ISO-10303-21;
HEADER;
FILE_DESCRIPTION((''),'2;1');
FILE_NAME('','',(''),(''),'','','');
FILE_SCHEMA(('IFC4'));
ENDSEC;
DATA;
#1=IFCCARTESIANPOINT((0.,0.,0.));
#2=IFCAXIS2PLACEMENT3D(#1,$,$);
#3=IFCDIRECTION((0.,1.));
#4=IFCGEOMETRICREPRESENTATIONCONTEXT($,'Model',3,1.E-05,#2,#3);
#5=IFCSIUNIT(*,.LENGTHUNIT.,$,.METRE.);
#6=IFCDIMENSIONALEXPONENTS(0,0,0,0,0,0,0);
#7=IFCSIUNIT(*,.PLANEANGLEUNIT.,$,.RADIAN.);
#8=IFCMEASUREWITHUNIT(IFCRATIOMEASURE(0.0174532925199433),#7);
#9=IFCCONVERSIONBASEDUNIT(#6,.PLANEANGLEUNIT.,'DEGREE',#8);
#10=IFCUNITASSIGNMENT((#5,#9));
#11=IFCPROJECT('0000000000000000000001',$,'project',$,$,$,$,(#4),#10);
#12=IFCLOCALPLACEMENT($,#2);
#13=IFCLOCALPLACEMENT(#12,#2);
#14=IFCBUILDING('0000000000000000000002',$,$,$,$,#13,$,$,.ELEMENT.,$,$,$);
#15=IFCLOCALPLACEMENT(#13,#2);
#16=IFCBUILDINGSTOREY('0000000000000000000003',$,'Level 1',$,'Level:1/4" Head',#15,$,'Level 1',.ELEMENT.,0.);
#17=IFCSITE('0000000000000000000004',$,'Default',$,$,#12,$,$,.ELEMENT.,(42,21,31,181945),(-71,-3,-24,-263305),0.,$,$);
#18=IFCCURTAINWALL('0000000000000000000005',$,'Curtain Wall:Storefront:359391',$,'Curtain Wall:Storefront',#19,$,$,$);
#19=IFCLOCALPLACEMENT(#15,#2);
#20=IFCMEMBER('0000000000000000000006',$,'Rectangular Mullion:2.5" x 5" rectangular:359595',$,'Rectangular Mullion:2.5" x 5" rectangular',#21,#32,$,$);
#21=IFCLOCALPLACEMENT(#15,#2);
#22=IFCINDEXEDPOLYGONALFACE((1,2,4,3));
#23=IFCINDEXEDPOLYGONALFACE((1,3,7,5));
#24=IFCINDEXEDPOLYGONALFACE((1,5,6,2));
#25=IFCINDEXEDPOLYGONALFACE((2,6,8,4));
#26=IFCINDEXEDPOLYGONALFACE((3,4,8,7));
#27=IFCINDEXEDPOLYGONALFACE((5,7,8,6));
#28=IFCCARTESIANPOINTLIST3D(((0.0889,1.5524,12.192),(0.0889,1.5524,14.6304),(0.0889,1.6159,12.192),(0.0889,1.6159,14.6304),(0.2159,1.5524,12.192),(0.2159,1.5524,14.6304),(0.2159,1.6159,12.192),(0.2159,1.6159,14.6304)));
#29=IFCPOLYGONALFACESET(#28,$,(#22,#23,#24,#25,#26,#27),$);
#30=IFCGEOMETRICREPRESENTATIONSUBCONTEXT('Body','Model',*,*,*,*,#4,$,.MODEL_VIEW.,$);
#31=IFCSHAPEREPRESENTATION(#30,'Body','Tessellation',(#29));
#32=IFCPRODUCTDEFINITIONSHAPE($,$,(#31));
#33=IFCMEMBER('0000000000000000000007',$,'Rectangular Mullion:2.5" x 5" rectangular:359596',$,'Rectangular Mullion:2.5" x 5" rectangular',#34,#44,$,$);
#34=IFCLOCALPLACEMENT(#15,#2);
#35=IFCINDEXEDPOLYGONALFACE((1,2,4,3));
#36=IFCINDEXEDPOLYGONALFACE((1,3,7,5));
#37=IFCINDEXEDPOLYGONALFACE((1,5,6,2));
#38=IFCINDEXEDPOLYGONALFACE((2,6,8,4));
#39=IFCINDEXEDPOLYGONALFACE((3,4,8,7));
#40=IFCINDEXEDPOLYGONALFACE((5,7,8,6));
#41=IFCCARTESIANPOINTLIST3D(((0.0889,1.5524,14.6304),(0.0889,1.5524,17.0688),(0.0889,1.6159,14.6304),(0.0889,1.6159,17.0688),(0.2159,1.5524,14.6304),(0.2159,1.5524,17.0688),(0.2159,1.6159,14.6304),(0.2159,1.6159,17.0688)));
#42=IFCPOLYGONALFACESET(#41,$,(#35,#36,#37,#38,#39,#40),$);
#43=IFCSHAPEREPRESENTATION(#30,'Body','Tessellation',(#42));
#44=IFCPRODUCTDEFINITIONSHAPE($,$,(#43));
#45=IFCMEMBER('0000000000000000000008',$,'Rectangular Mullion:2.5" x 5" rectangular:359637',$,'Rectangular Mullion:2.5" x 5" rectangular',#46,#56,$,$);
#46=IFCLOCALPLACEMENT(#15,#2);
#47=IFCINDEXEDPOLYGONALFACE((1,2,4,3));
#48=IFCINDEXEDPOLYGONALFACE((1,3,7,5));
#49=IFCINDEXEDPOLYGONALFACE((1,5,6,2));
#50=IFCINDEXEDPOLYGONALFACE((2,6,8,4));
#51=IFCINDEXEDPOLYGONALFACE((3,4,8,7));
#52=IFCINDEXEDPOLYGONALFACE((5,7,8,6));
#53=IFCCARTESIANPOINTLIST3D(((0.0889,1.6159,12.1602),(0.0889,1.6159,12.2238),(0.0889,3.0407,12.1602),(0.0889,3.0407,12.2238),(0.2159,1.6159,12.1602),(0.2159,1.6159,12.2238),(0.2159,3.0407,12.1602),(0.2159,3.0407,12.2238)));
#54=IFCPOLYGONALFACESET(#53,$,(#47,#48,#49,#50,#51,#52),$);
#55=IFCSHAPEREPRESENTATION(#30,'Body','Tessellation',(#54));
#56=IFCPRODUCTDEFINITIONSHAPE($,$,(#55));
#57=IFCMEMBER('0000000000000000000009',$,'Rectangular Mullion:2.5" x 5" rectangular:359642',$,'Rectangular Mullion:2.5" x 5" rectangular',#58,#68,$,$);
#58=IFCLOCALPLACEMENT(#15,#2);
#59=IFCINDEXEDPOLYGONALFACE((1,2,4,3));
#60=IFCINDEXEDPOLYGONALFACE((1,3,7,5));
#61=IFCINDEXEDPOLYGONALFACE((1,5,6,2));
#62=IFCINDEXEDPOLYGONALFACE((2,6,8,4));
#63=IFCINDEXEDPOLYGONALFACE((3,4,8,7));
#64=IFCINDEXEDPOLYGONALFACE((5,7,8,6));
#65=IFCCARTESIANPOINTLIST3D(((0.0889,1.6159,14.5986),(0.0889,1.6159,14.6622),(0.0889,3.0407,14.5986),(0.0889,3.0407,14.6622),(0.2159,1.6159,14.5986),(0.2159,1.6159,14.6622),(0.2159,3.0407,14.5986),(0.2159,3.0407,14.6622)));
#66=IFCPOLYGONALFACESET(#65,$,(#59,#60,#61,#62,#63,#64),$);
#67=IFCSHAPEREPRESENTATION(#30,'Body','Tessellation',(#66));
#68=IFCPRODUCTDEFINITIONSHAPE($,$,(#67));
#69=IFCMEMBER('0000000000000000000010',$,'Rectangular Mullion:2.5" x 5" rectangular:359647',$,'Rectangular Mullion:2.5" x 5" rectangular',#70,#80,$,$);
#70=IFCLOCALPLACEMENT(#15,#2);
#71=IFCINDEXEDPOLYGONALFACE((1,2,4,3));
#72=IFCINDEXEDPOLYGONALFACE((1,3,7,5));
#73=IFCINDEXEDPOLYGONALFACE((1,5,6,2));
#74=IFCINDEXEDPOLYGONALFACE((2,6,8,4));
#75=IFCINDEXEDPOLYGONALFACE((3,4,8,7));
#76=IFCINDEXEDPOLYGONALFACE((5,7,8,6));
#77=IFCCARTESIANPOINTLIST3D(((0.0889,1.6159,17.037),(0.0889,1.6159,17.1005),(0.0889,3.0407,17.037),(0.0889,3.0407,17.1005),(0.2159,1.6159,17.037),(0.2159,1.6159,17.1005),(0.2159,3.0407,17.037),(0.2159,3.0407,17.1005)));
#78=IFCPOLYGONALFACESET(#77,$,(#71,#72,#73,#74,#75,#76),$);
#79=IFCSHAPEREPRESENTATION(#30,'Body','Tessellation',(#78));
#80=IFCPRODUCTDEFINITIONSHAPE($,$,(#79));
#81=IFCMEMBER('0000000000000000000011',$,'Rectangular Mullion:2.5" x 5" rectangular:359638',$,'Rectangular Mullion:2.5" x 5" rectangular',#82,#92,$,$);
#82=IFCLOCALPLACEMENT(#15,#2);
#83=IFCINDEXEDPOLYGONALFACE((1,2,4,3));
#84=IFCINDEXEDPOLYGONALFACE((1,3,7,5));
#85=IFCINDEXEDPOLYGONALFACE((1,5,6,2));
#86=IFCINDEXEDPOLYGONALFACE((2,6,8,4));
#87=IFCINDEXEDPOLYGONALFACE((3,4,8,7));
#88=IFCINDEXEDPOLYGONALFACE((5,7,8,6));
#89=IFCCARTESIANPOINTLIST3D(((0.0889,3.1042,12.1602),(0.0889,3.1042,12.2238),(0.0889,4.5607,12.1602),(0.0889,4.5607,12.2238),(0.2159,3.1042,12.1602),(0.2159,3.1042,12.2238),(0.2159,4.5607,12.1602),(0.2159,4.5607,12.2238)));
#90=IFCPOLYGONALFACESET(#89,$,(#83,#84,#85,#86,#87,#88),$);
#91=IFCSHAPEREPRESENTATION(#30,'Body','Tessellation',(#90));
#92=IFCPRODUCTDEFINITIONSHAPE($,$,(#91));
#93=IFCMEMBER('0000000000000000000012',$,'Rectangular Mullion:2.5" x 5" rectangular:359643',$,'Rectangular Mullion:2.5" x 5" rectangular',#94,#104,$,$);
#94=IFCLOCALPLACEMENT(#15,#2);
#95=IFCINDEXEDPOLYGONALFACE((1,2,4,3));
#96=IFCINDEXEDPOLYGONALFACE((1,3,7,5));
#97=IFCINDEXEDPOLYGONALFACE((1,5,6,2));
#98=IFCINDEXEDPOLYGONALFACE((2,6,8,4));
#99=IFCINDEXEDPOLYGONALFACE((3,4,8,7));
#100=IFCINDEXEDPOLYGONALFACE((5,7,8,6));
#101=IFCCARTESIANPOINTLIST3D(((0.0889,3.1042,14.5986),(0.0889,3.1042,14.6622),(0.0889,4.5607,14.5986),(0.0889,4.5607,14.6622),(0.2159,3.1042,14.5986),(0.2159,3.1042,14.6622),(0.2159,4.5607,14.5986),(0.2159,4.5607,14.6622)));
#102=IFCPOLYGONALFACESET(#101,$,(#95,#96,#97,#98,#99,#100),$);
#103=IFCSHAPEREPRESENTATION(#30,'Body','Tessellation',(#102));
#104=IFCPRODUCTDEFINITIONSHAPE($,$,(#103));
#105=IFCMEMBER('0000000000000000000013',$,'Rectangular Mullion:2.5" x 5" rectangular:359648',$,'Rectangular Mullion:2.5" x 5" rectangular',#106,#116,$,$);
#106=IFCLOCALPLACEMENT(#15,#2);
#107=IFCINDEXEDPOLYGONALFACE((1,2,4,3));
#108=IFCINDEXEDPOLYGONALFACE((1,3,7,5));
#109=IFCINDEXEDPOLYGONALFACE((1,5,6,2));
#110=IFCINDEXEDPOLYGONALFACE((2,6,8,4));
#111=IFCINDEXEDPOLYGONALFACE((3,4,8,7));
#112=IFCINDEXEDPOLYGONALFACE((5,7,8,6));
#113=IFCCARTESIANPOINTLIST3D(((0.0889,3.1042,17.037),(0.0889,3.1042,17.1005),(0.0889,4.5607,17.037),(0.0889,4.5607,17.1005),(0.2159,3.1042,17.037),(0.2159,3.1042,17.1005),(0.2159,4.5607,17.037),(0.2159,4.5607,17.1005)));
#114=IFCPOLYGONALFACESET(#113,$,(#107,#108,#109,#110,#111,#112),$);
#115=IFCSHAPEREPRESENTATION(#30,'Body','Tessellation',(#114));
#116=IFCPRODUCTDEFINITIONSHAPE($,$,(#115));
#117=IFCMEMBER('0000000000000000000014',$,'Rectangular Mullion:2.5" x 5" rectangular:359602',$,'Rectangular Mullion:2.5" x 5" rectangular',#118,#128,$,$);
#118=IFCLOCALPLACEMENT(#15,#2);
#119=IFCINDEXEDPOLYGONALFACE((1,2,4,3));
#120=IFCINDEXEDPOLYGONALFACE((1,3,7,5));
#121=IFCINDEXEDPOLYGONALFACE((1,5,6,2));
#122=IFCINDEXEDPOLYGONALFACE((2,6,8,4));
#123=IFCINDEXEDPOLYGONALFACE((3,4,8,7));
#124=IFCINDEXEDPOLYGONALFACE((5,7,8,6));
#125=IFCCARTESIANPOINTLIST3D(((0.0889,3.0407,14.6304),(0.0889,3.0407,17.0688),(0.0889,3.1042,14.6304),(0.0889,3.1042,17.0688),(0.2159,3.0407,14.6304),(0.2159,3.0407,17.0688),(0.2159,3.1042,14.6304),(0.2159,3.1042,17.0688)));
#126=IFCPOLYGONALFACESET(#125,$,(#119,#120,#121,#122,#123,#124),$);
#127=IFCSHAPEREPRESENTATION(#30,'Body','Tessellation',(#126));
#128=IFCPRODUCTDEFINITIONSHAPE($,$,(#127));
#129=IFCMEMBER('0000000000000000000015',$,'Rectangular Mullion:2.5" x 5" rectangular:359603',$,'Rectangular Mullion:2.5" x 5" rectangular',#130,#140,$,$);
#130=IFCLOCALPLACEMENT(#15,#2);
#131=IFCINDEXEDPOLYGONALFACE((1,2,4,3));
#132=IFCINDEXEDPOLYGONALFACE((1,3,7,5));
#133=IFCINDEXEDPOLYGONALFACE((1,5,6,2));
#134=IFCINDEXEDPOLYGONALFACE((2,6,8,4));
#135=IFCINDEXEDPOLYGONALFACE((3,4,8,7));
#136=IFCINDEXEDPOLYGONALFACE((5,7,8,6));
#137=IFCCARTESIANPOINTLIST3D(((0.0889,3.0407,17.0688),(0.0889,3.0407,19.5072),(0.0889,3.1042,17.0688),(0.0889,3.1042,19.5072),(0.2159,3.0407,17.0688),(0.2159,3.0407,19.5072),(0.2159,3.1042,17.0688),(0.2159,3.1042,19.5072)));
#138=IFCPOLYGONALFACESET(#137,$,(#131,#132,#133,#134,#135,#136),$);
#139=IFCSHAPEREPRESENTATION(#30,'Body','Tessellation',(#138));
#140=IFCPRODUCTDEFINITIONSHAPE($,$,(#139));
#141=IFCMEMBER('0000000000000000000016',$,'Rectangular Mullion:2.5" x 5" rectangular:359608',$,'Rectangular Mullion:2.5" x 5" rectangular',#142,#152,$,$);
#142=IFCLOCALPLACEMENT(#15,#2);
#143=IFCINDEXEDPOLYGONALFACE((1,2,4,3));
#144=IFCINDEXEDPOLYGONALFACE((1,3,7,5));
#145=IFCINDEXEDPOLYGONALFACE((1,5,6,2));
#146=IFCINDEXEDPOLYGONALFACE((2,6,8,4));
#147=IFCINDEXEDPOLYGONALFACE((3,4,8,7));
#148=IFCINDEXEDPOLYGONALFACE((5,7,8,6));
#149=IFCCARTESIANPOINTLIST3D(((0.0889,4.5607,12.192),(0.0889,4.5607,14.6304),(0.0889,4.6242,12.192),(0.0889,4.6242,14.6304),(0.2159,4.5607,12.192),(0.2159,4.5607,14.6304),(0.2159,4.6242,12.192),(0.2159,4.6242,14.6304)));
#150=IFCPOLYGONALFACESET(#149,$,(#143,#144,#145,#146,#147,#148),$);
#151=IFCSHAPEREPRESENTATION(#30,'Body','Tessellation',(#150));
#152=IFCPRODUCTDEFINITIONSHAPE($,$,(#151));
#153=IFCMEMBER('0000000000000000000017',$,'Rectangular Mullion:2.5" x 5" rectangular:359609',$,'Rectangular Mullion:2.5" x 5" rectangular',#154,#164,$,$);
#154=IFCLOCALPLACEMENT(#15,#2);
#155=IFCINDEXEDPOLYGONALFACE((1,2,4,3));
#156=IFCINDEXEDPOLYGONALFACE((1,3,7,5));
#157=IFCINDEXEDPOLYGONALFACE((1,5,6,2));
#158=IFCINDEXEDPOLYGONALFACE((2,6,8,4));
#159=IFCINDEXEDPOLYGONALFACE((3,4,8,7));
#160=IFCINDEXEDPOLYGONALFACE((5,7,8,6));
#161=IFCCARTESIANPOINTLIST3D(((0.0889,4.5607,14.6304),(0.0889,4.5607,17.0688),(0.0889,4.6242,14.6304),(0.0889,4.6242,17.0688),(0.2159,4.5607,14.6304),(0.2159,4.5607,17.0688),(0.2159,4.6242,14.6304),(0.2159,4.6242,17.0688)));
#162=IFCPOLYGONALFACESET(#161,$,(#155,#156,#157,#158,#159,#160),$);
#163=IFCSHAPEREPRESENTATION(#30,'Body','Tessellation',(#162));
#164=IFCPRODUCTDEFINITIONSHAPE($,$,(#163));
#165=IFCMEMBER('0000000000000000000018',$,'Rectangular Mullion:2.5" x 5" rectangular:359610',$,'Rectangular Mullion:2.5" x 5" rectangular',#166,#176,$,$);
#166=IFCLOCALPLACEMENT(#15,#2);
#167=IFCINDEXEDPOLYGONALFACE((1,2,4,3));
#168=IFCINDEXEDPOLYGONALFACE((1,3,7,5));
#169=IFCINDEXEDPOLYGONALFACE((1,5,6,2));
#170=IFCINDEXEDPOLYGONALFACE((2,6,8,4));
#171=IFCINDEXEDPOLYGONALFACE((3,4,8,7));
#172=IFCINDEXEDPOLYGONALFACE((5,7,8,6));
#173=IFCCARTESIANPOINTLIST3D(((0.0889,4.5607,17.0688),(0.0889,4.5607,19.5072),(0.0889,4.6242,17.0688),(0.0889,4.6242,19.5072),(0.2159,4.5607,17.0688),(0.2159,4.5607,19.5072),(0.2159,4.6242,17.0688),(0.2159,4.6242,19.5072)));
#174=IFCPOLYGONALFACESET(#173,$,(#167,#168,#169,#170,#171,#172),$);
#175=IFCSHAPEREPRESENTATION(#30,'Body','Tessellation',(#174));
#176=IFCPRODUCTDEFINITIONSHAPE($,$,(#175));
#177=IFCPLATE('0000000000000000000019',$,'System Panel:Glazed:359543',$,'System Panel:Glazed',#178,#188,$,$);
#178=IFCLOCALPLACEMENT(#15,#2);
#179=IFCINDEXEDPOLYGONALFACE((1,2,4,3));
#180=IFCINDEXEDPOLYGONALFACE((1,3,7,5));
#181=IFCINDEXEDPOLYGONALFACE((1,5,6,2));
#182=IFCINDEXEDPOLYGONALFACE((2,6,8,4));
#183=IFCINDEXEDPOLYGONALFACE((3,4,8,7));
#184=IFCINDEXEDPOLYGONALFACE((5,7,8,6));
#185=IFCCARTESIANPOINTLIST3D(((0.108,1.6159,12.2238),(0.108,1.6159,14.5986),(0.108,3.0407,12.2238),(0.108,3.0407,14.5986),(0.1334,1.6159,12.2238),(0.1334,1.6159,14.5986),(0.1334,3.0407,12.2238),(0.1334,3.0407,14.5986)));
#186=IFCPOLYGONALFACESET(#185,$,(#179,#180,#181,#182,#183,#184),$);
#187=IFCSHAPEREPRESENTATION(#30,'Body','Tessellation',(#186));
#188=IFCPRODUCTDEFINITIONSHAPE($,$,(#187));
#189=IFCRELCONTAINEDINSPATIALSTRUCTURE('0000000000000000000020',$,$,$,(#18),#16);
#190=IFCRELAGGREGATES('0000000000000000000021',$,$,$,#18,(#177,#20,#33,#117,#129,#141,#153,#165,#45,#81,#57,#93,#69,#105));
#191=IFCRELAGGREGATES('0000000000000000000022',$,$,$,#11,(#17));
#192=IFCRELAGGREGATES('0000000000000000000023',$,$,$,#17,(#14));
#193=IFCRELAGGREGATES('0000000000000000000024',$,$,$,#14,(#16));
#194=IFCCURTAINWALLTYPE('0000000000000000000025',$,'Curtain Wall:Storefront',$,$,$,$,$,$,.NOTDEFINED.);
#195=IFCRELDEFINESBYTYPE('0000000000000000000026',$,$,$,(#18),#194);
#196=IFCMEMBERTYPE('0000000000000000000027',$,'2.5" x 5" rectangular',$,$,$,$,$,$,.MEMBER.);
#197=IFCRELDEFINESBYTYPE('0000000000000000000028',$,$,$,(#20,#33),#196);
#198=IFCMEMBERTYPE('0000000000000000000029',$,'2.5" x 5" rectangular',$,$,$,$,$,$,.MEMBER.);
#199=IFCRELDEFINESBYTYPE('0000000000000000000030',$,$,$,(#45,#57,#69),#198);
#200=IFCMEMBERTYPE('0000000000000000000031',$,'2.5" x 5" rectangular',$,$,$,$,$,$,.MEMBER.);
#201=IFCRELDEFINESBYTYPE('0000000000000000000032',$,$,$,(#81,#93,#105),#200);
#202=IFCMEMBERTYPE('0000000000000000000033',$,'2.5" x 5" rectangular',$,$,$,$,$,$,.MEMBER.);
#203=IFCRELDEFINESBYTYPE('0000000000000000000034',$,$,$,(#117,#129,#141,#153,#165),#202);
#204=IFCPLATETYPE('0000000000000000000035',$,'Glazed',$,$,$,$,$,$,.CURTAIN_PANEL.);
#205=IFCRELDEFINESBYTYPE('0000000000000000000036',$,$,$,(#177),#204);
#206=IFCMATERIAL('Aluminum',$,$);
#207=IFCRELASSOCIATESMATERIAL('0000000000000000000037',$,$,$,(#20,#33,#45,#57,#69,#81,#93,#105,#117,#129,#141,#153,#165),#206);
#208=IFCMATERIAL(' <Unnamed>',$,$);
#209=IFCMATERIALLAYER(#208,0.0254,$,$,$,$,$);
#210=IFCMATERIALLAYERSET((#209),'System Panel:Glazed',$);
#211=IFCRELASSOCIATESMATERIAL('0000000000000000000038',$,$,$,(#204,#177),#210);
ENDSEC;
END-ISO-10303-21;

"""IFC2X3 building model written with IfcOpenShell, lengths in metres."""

from ifc_helpers import new_model, entity, si_unit, converted_unit, direction, frame, frame_2d, origin, origin_2d_with_axis, place, context, subcontext, project, spatial, rectangle, extrude, source, transform, mapped, material, layer, layer_set, layer_usage, type_object, type_shapes, element, aggregate, save


model = new_model("IFC2X3")

# Units and contexts
model_context = context("Model", 3, precision=1e-05, world=origin(), true_north=direction((0.0, 1.0)))
body_context = subcontext(model_context, "Body", "Model", "MODEL_VIEW")
ifc_project = project(units=[si_unit("LENGTHUNIT", "METRE"), converted_unit("PLANEANGLEUNIT", "DEGREE", entity("IfcRatioMeasure", 0.0174532925199433), si_unit("PLANEANGLEUNIT", "RADIAN"), dimensions=[0, 0, 0, 0, 0, 0, 0])], contexts=[model_context])

# Site, building, storey
site_placement = place(None, origin())
site = spatial("IfcSite", under=ifc_project, at=site_placement, Name="Default", CompositionType="ELEMENT", RefLatitude=(42, 21, 31, 181945), RefLongitude=(-71, -3, -24, -263305), RefElevation=0.0)
building_placement = place(site_placement, origin())
building = spatial("IfcBuilding", under=site, at=building_placement, CompositionType="ELEMENT")
storey_placement = place(building_placement, origin())
storey = spatial("IfcBuildingStorey", under=building, at=storey_placement, Name="Level 1", ObjectType="Level:1/4\" Head", LongName="Level 1", CompositionType="ELEMENT", Elevation=0.0)

# Curtain wall, members, plate
curtain_wall_type = type_object("IfcCurtainWallType", Name="Curtain Wall:Storefront", PredefinedType="NOTDEFINED")
curtain_wall_placement = place(storey_placement, origin())
curtain_wall = element("IfcCurtainWall", 1, at=curtain_wall_placement, inside=storey, type_object=curtain_wall_type, Name="Curtain Wall:Storefront:359391", ObjectType="Curtain Wall:Storefront")
ifc_material_1 = material(Name="Aluminum")
member_type_1 = type_object("IfcMemberType", Name="2.5\" x 5\" rectangular", PredefinedType="MEMBER")
shared_shape_1 = source(origin(), body_context, "Body", "SweptSolid", [
    extrude(rectangle(XDim=0.127, YDim=0.0635, at=origin_2d_with_axis()), frame((-0.0318, 0.0, -2.4384), z_axis=(0.0, 0.0, 1.0), x_axis=(0.0, -1.0, 0.0)), (0.0, 0.0, 1.0), 2.4384),
])
type_shapes(member_type_1, [shared_shape_1])
member_1_placement = place(storey_placement, frame((0.1524, 1.5524, 14.6304), z_axis=(0.0, 0.0, 1.0), x_axis=(0.0, -1.0, 0.0)))
member_1 = element("IfcMember", 2, at=member_1_placement, type_object=member_type_1, material=ifc_material_1, Name="Rectangular Mullion:2.5\" x 5\" rectangular:359595", ObjectType="Rectangular Mullion:2.5\" x 5\" rectangular", context=body_context, shape_type="MappedRepresentation", body=[
    mapped(shared_shape_1, transform((0.0, 0.0, 0.0), scale=1.0)),
])
member_2_placement = place(storey_placement, frame((0.1524, 1.5524, 17.0688), z_axis=(0.0, 0.0, 1.0), x_axis=(0.0, -1.0, 0.0)))
member_2 = element("IfcMember", 3, at=member_2_placement, type_object=member_type_1, material=ifc_material_1, Name="Rectangular Mullion:2.5\" x 5\" rectangular:359596", ObjectType="Rectangular Mullion:2.5\" x 5\" rectangular", context=body_context, shape_type="MappedRepresentation", body=[
    mapped(shared_shape_1, transform((0.0, 0.0, 0.0), scale=1.0)),
])
member_type_2 = type_object("IfcMemberType", Name="2.5\" x 5\" rectangular", PredefinedType="MEMBER")
shared_shape_2 = source(origin(), body_context, "Body", "SweptSolid", [
    extrude(rectangle(XDim=0.127, YDim=0.0635, at=origin_2d_with_axis()), frame((0.0, 0.0, -1.4248), z_axis=(0.0, 0.0, 1.0), x_axis=(0.0, -1.0, 0.0)), (0.0, 0.0, 1.0), 1.4248),
])
type_shapes(member_type_2, [shared_shape_2])
member_3_placement = place(storey_placement, frame((0.1524, 3.0407, 12.192), z_axis=(0.0, 1.0, 0.0), x_axis=(0.0, 0.0, 1.0)))
member_3 = element("IfcMember", 4, at=member_3_placement, type_object=member_type_2, material=ifc_material_1, Name="Rectangular Mullion:2.5\" x 5\" rectangular:359637", ObjectType="Rectangular Mullion:2.5\" x 5\" rectangular", context=body_context, shape_type="MappedRepresentation", body=[
    mapped(shared_shape_2, transform((0.0, 0.0, 0.0), scale=1.0)),
])
member_4_placement = place(storey_placement, frame((0.1524, 3.0407, 14.6304), z_axis=(0.0, 1.0, 0.0), x_axis=(0.0, 0.0, 1.0)))
member_4 = element("IfcMember", 5, at=member_4_placement, type_object=member_type_2, material=ifc_material_1, Name="Rectangular Mullion:2.5\" x 5\" rectangular:359642", ObjectType="Rectangular Mullion:2.5\" x 5\" rectangular", context=body_context, shape_type="MappedRepresentation", body=[
    mapped(shared_shape_2, transform((0.0, 0.0, 0.0), scale=1.0)),
])
member_5_placement = place(storey_placement, frame((0.1524, 3.0407, 17.0688), z_axis=(0.0, 1.0, 0.0), x_axis=(0.0, 0.0, 1.0)))
member_5 = element("IfcMember", 6, at=member_5_placement, type_object=member_type_2, material=ifc_material_1, Name="Rectangular Mullion:2.5\" x 5\" rectangular:359647", ObjectType="Rectangular Mullion:2.5\" x 5\" rectangular", context=body_context, shape_type="MappedRepresentation", body=[
    mapped(shared_shape_2, transform((0.0, 0.0, 0.0), scale=1.0)),
])
member_type_3 = type_object("IfcMemberType", Name="2.5\" x 5\" rectangular", PredefinedType="MEMBER")
shared_shape_3 = source(origin(), body_context, "Body", "SweptSolid", [
    extrude(rectangle(XDim=0.127, YDim=0.0635, at=origin_2d_with_axis()), frame((0.0, 0.0, -1.4565), z_axis=(0.0, 0.0, 1.0), x_axis=(0.0, -1.0, 0.0)), (0.0, 0.0, 1.0), 1.4565),
])
type_shapes(member_type_3, [shared_shape_3])
member_6_placement = place(storey_placement, frame((0.1524, 4.5607, 12.192), z_axis=(0.0, 1.0, 0.0), x_axis=(0.0, 0.0, 1.0)))
member_6 = element("IfcMember", 7, at=member_6_placement, type_object=member_type_3, material=ifc_material_1, Name="Rectangular Mullion:2.5\" x 5\" rectangular:359638", ObjectType="Rectangular Mullion:2.5\" x 5\" rectangular", context=body_context, shape_type="MappedRepresentation", body=[
    mapped(shared_shape_3, transform((0.0, 0.0, 0.0), scale=1.0)),
])
member_7_placement = place(storey_placement, frame((0.1524, 4.5607, 14.6304), z_axis=(0.0, 1.0, 0.0), x_axis=(0.0, 0.0, 1.0)))
member_7 = element("IfcMember", 8, at=member_7_placement, type_object=member_type_3, material=ifc_material_1, Name="Rectangular Mullion:2.5\" x 5\" rectangular:359643", ObjectType="Rectangular Mullion:2.5\" x 5\" rectangular", context=body_context, shape_type="MappedRepresentation", body=[
    mapped(shared_shape_3, transform((0.0, 0.0, 0.0), scale=1.0)),
])
member_8_placement = place(storey_placement, frame((0.1524, 4.5607, 17.0688), z_axis=(0.0, 1.0, 0.0), x_axis=(0.0, 0.0, 1.0)))
member_8 = element("IfcMember", 9, at=member_8_placement, type_object=member_type_3, material=ifc_material_1, Name="Rectangular Mullion:2.5\" x 5\" rectangular:359648", ObjectType="Rectangular Mullion:2.5\" x 5\" rectangular", context=body_context, shape_type="MappedRepresentation", body=[
    mapped(shared_shape_3, transform((0.0, 0.0, 0.0), scale=1.0)),
])
member_type_4 = type_object("IfcMemberType", Name="2.5\" x 5\" rectangular", PredefinedType="MEMBER")
shared_shape_4 = source(origin(), body_context, "Body", "SweptSolid", [
    extrude(rectangle(XDim=0.127, YDim=0.0635, at=origin_2d_with_axis()), frame((0.0, 0.0, -2.4384), z_axis=(0.0, 0.0, 1.0), x_axis=(0.0, -1.0, 0.0)), (0.0, 0.0, 1.0), 2.4384),
])
type_shapes(member_type_4, [shared_shape_4])
member_9_placement = place(storey_placement, frame((0.1524, 3.0724, 14.6304), z_axis=(0.0, 0.0, -1.0), x_axis=(0.0, 1.0, 0.0)))
member_9 = element("IfcMember", 10, at=member_9_placement, type_object=member_type_4, material=ifc_material_1, Name="Rectangular Mullion:2.5\" x 5\" rectangular:359602", ObjectType="Rectangular Mullion:2.5\" x 5\" rectangular", context=body_context, shape_type="MappedRepresentation", body=[
    mapped(shared_shape_4, transform((0.0, 0.0, 0.0), scale=1.0)),
])
member_10_placement = place(storey_placement, frame((0.1524, 3.0724, 17.0688), z_axis=(0.0, 0.0, -1.0), x_axis=(0.0, 1.0, 0.0)))
member_10 = element("IfcMember", 11, at=member_10_placement, type_object=member_type_4, material=ifc_material_1, Name="Rectangular Mullion:2.5\" x 5\" rectangular:359603", ObjectType="Rectangular Mullion:2.5\" x 5\" rectangular", context=body_context, shape_type="MappedRepresentation", body=[
    mapped(shared_shape_4, transform((0.0, 0.0, 0.0), scale=1.0)),
])
member_11_placement = place(storey_placement, frame((0.1524, 4.5924, 12.192), z_axis=(0.0, 0.0, -1.0), x_axis=(0.0, 1.0, 0.0)))
member_11 = element("IfcMember", 12, at=member_11_placement, type_object=member_type_4, material=ifc_material_1, Name="Rectangular Mullion:2.5\" x 5\" rectangular:359608", ObjectType="Rectangular Mullion:2.5\" x 5\" rectangular", context=body_context, shape_type="MappedRepresentation", body=[
    mapped(shared_shape_4, transform((0.0, 0.0, 0.0), scale=1.0)),
])
member_12_placement = place(storey_placement, frame((0.1524, 4.5924, 14.6304), z_axis=(0.0, 0.0, -1.0), x_axis=(0.0, 1.0, 0.0)))
member_12 = element("IfcMember", 13, at=member_12_placement, type_object=member_type_4, material=ifc_material_1, Name="Rectangular Mullion:2.5\" x 5\" rectangular:359609", ObjectType="Rectangular Mullion:2.5\" x 5\" rectangular", context=body_context, shape_type="MappedRepresentation", body=[
    mapped(shared_shape_4, transform((0.0, 0.0, 0.0), scale=1.0)),
])
member_13_placement = place(storey_placement, frame((0.1524, 4.5924, 17.0688), z_axis=(0.0, 0.0, -1.0), x_axis=(0.0, 1.0, 0.0)))
member_13 = element("IfcMember", 14, at=member_13_placement, type_object=member_type_4, material=ifc_material_1, Name="Rectangular Mullion:2.5\" x 5\" rectangular:359610", ObjectType="Rectangular Mullion:2.5\" x 5\" rectangular", context=body_context, shape_type="MappedRepresentation", body=[
    mapped(shared_shape_4, transform((0.0, 0.0, 0.0), scale=1.0)),
])
ifc_material_2 = material(Name=" <Unnamed>")
ifc_layer = layer(ifc_material_2, 0.0254)
ifc_layer_set = layer_set([ifc_layer], Name="System Panel:Glazed")
ifc_layer_usage_1 = layer_usage(ifc_layer_set, "AXIS3", "POSITIVE", 0.1042)
plate_type_1 = type_object("IfcPlateType", Name="Glazed", PredefinedType="CURTAIN_PANEL", material=ifc_layer_set)
shared_shape_5 = source(origin(), body_context, "Body", "SweptSolid", [
    extrude(rectangle(XDim=0.0254, YDim=1.4248, at=frame_2d((0.0, 0.0), x_axis=(1.0, 0.0))), frame((0.7124, 0.0127, 0.0), z_axis=(0.0, 0.0, 1.0), x_axis=(0.0, 1.0, 0.0)), (0.0, 0.0, 1.0), 2.3749),
])
type_shapes(plate_type_1, [shared_shape_5])
plate_1_placement = place(curtain_wall_placement, frame((0.1334, 1.6159, 12.2238), z_axis=(0.0, 0.0, 1.0), x_axis=(0.0, 1.0, 0.0)))
plate_1 = element("IfcPlate", 15, at=plate_1_placement, type_object=plate_type_1, material=ifc_layer_usage_1, Name="System Panel:Glazed:359543", ObjectType="System Panel:Glazed", context=body_context, shape_type="MappedRepresentation", body=[
    mapped(shared_shape_5, transform((0.0, 0.0, 0.0), scale=1.0)),
])
aggregate(curtain_wall, [plate_1, member_1, member_2, member_9, member_10, member_11, member_12, member_13, member_3, member_6, member_4, member_7, member_5, member_8])

save(model, "model.ifc")
